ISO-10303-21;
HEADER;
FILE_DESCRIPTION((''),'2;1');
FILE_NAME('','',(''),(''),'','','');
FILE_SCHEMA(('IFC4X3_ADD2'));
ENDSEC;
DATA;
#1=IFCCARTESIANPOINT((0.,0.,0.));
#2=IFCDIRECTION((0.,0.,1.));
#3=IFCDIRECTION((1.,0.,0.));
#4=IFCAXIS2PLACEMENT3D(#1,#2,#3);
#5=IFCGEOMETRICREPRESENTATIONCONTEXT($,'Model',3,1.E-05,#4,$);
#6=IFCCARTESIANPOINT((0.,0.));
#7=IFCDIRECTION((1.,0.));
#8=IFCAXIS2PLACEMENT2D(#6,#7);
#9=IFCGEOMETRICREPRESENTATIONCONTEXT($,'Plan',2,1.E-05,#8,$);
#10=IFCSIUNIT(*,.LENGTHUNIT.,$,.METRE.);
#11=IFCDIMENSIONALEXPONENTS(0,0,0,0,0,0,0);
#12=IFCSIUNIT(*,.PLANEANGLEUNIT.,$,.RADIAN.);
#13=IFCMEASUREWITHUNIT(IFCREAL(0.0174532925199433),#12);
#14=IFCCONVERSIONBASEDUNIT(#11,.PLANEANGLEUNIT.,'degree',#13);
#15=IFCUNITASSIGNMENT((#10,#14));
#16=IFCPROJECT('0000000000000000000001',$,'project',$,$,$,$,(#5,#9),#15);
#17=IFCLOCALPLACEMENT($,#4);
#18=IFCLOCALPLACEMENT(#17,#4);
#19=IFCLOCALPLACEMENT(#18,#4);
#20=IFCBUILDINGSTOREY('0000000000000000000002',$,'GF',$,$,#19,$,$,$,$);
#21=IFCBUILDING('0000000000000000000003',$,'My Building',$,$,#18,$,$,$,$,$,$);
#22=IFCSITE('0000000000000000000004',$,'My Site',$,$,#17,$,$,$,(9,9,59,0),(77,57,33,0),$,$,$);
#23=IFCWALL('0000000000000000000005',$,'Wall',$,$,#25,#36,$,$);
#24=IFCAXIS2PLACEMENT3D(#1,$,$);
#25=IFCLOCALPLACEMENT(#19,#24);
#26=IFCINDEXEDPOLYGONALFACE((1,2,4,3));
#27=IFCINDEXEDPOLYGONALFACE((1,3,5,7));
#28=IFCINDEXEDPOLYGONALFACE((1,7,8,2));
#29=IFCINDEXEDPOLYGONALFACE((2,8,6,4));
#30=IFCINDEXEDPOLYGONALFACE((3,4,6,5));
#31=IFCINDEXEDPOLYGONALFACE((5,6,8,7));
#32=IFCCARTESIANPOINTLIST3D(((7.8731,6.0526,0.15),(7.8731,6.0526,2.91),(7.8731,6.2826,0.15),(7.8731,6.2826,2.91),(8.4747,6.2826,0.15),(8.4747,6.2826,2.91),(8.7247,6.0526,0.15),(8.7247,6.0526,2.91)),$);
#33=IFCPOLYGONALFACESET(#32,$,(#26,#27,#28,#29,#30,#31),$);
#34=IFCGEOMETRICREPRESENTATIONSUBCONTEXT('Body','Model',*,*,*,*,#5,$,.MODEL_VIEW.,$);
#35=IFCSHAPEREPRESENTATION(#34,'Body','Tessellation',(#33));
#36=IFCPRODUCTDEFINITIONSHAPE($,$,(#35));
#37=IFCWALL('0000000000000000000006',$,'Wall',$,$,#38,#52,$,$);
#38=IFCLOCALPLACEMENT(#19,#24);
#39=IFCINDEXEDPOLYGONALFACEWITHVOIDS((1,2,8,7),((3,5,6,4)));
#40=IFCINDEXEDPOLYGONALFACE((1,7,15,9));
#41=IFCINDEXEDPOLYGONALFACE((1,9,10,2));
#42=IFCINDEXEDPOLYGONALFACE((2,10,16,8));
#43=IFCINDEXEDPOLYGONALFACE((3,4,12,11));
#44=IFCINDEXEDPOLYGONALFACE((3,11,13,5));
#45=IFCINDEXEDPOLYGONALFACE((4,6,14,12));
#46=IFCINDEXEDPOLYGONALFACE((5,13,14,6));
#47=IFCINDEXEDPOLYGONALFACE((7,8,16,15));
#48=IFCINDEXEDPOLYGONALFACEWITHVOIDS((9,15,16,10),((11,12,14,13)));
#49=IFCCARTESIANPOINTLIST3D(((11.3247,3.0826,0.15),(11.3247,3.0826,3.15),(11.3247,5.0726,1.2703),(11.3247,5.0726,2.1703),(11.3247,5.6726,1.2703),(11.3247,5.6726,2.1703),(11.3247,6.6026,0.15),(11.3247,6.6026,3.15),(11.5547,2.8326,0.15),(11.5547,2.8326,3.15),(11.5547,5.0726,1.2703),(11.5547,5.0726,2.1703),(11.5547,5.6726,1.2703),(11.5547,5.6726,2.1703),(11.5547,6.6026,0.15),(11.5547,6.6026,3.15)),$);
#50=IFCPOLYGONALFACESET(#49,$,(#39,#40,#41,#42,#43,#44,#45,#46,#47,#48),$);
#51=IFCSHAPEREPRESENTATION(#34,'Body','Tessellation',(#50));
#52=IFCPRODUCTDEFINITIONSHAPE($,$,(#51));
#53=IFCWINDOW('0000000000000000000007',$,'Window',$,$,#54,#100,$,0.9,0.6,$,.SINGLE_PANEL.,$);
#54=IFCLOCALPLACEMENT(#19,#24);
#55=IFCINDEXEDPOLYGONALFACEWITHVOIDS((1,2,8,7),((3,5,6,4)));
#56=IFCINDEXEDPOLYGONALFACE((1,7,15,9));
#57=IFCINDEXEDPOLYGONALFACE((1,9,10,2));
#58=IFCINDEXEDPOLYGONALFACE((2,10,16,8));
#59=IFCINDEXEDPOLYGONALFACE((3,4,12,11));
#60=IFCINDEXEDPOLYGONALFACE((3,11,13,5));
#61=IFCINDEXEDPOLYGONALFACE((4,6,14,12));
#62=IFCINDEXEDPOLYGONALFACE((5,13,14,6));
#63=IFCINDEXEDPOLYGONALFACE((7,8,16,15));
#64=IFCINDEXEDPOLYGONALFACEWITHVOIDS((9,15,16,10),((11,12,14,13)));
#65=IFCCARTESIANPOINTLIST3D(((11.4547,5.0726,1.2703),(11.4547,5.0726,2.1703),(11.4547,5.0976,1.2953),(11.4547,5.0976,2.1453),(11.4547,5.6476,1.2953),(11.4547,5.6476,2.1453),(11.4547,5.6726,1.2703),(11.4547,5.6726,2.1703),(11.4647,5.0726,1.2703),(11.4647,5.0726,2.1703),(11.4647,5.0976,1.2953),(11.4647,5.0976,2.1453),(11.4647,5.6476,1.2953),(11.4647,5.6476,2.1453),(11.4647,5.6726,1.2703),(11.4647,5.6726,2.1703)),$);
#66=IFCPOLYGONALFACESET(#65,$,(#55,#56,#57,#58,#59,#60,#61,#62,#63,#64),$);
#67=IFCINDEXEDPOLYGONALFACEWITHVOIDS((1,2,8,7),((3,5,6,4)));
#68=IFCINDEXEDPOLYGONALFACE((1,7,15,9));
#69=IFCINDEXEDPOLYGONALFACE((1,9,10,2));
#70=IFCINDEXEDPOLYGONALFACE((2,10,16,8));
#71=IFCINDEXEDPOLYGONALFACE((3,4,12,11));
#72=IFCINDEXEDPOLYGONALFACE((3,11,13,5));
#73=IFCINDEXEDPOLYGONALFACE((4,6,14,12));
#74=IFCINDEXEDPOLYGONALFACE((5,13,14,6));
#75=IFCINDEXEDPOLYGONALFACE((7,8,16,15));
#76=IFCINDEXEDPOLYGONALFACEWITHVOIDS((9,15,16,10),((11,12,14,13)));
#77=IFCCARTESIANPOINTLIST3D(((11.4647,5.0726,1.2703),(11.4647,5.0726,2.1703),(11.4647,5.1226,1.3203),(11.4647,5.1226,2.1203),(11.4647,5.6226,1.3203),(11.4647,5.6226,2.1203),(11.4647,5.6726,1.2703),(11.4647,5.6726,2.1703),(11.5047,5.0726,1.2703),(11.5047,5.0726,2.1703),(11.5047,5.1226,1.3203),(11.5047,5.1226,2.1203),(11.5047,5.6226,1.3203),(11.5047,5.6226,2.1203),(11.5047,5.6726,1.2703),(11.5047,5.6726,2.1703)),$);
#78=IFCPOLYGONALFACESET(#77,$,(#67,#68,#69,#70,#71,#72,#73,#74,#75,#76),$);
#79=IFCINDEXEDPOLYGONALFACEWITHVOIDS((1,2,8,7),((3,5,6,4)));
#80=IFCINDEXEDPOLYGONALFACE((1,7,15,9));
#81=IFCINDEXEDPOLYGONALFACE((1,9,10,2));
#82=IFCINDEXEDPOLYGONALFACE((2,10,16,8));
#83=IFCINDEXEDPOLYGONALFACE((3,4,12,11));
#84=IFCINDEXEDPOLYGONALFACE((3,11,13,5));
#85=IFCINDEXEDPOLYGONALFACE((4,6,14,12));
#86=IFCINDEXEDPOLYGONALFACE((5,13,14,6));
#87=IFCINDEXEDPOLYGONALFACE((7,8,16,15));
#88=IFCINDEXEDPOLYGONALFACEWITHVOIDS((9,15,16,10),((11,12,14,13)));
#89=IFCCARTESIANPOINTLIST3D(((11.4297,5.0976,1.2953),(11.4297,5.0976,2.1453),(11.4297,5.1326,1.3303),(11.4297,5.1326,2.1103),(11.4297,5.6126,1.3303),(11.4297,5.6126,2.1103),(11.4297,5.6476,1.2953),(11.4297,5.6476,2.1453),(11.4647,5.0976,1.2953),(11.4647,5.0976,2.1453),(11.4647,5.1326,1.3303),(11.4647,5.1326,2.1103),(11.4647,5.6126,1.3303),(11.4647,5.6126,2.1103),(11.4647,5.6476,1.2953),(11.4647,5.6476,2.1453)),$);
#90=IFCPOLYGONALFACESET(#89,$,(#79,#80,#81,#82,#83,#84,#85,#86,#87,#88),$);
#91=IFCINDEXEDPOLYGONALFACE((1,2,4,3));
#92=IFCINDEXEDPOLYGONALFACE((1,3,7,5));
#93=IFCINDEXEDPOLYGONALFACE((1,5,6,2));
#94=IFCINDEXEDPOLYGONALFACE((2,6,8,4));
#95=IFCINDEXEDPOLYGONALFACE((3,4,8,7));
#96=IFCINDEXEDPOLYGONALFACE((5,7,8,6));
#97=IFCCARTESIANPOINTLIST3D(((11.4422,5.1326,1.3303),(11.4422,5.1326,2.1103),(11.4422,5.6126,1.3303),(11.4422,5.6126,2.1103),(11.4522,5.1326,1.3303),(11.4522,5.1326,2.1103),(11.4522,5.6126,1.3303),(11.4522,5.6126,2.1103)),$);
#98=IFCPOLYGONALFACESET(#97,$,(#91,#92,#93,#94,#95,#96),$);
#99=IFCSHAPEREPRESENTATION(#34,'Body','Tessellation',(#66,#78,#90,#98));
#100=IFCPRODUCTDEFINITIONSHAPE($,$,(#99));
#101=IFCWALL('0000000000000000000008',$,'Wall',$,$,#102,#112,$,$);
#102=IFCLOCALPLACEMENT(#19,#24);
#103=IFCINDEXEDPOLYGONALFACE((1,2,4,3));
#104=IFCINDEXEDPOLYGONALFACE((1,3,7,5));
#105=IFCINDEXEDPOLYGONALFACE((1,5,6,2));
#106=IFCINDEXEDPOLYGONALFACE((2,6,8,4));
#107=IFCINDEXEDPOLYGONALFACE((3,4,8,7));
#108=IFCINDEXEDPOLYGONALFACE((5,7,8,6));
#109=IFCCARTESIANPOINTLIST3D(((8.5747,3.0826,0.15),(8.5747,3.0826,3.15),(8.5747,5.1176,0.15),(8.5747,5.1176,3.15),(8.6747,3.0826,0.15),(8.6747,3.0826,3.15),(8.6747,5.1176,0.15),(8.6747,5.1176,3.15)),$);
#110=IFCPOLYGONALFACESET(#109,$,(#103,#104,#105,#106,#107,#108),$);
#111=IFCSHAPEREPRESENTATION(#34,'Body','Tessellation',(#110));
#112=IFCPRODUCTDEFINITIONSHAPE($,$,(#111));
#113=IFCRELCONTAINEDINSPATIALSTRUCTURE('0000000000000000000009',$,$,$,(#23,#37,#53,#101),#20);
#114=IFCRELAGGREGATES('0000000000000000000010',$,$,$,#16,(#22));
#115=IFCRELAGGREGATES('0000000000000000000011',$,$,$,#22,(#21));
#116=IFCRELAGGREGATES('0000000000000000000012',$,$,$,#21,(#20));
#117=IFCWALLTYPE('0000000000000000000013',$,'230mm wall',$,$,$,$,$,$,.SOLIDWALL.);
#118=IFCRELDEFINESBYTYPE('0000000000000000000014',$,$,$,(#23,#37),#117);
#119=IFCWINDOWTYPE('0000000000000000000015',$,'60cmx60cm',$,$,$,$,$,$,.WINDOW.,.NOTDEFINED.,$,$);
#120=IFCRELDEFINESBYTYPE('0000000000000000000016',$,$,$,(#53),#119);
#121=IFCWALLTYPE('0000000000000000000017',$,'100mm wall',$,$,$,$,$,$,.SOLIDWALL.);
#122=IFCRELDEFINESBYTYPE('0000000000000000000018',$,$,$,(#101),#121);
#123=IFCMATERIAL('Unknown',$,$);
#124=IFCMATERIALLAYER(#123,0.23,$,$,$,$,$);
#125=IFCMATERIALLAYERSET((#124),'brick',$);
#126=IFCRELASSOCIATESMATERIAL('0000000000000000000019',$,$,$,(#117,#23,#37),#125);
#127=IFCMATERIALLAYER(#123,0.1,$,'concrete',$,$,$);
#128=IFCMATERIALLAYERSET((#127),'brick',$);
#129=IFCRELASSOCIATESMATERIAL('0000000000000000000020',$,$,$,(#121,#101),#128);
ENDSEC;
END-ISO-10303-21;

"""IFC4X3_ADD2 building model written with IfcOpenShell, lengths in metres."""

from ifc_helpers import new_model, entity, si_unit, converted_unit, frame, origin_with_axes, origin_2d_with_axis, place, context, subcontext, project, spatial, line, indexed_curve, outline, extrude, shape, source, transform, mapped, material, layer, layer_set, layer_usage, type_object, type_shapes, element, fill, save


model = new_model("IFC4X3_ADD2")

# Units and contexts
model_context = context("Model", 3, precision=1e-05, world=origin_with_axes())
plan_context = context("Plan", 2, precision=1e-05, world=origin_2d_with_axis())
body_context_1 = subcontext(model_context, "Body", "Model", "MODEL_VIEW")
body_context_2 = subcontext(plan_context, "Body", "Plan", "PLAN_VIEW")
ifc_project = project(units=[si_unit("LENGTHUNIT", "METRE"), converted_unit("PLANEANGLEUNIT", "degree", entity("IfcReal", 0.0174532925199433), si_unit("PLANEANGLEUNIT", "RADIAN"), dimensions=[0, 0, 0, 0, 0, 0, 0])], contexts=[model_context, plan_context])

# Site, building, storey
site_placement = place(None, origin_with_axes())
site = spatial("IfcSite", under=ifc_project, at=site_placement, Name="My Site", RefLatitude=(9, 9, 59, 0), RefLongitude=(77, 57, 33, 0))
building_placement = place(site_placement, origin_with_axes())
building = spatial("IfcBuilding", under=site, at=building_placement, Name="My Building")
storey_placement = place(building_placement, origin_with_axes())
storey = spatial("IfcBuildingStorey", under=building, at=storey_placement, Name="GF")

# Shared definitions
ifc_material_1 = material(Name="Unknown")

# Shared definitions
shared_shape_1 = source(origin_with_axes(), body_context_1, "Body", "SweptSolid", [
    extrude(outline(indexed_curve([(0.0, 0.0), (0.6, 0.0), (0.6, 0.9), (0.0, 0.9)], segments=[line(1, 2, 3, 4, 1)])), frame((0.0, -0.6, 0.0), z_axis=(0.0, -1.0, 0.0), x_axis=(1.0, 0.0, 0.0)), (0.0, 0.0, -1.0), 1.2),
])
window_type = type_object("IfcWindowType", Name="60cmx60cm", PartitioningType="NOTDEFINED", PredefinedType="WINDOW")
shared_shape_2 = source(origin_with_axes(), body_context_1, "Body", "SweptSolid", [
    extrude(outline(indexed_curve([(0.0, 0.0), (0.6, 0.0), (0.6, 0.9), (0.0, 0.9)], segments=[line(1, 2, 3, 4, 1)]), holes=[indexed_curve([(0.025, 0.025), (0.575, 0.025), (0.575, 0.875), (0.025, 0.875)], segments=[line(1, 2, 3, 4, 1)])]), frame((0.0, 0.09, 0.0), z_axis=(0.0, -1.0, 0.0), x_axis=(1.0, 0.0, 0.0)), (0.0, 0.0, -1.0), 0.01),
    extrude(outline(indexed_curve([(0.0, 0.0), (0.6, 0.0), (0.6, 0.9), (0.0, 0.9)], segments=[line(1, 2, 3, 4, 1)]), holes=[indexed_curve([(0.05, 0.05), (0.55, 0.05), (0.55, 0.85), (0.05, 0.85)], segments=[line(1, 2, 3, 4, 1)])]), frame((0.0, 0.05, 0.0), z_axis=(0.0, -1.0, 0.0), x_axis=(1.0, 0.0, 0.0)), (0.0, 0.0, -1.0), 0.04),
    extrude(outline(indexed_curve([(0.0, 0.0), (0.55, 0.0), (0.55, 0.85), (0.0, 0.85)], segments=[line(1, 2, 3, 4, 1)]), holes=[indexed_curve([(0.035, 0.035), (0.515, 0.035), (0.515, 0.815), (0.035, 0.815)], segments=[line(1, 2, 3, 4, 1)])]), frame((0.025, 0.09, 0.025), z_axis=(0.0, -1.0, 0.0), x_axis=(1.0, 0.0, 0.0)), (0.0, 0.0, -1.0), 0.035),
    extrude(outline(indexed_curve([(0.035, 0.035), (0.515, 0.035), (0.515, 0.815), (0.035, 0.815)], segments=[line(1, 2, 3, 4, 1)])), frame((0.025, 0.1025, 0.025), z_axis=(0.0, -1.0, 0.0), x_axis=(1.0, 0.0, 0.0)), (0.0, 0.0, -1.0), 0.01),
])
shared_shape_3 = source(origin_with_axes(), body_context_2, "Body", "Curve2D", [
    entity("IfcIndexedPolyCurve", entity("IfcCartesianPointList2D", [[0.05, 0.05], [0.55, 0.05]])),
    entity("IfcIndexedPolyCurve", entity("IfcCartesianPointList2D", [[0.0, 0.1], [0.025, 0.1], [0.025, 0.09], [0.05, 0.09], [0.05, 0.05], [0.0, 0.05]]), [entity("IfcLineIndex", [1, 2, 3, 4, 5, 6, 1])]),
    entity("IfcIndexedPolyCurve", entity("IfcCartesianPointList2D", [[0.6, 0.1], [0.575, 0.1], [0.575, 0.09], [0.55, 0.09], [0.55, 0.05], [0.6, 0.05]]), [entity("IfcLineIndex", [1, 2, 3, 4, 5, 6, 1])]),
    entity("IfcIndexedPolyCurve", entity("IfcCartesianPointList2D", [[0.025, 0.09], [0.06, 0.09], [0.06, 0.125], [0.025, 0.125]]), [entity("IfcLineIndex", [1, 2, 3, 4, 1])]),
    entity("IfcIndexedPolyCurve", entity("IfcCartesianPointList2D", [[0.575, 0.09], [0.54, 0.09], [0.54, 0.125], [0.575, 0.125]]), [entity("IfcLineIndex", [1, 2, 3, 4, 1])]),
    entity("IfcIndexedPolyCurve", entity("IfcCartesianPointList2D", [[0.06, 0.09], [0.54, 0.09]])),
    entity("IfcIndexedPolyCurve", entity("IfcCartesianPointList2D", [[0.06, 0.125], [0.54, 0.125]])),
    entity("IfcIndexedPolyCurve", entity("IfcCartesianPointList2D", [[0.06, 0.1075], [0.54, 0.1075]])),
])
type_shapes(window_type, [shared_shape_2, shared_shape_3])

# Shared definitions
ifc_layer_1 = layer(ifc_material_1, 0.23)
ifc_layer_set_1 = layer_set([ifc_layer_1], Name="brick")
wall_type_1 = type_object("IfcWallType", Name="230mm wall", PredefinedType="SOLIDWALL", material=ifc_layer_set_1)
wall_1_placement = place(storey_placement, frame((11.5547, 2.8326, 0.15), z_axis=(0.0, 0.0, 1.0), x_axis=(0.0, 1.0, 0.0)))
placement = place(wall_1_placement, frame((2.24, 0.0, 1.1203), z_axis=(0.0, 0.0, 1.0), x_axis=(1.0, 0.0, 0.0)))

# Wall
ifc_layer_usage_1 = layer_usage(ifc_layer_set_1, "AXIS2", "POSITIVE", 0.0)
wall_2_placement = place(storey_placement, frame((7.8731, 6.0526, 0.15), z_axis=(0.0, 0.0, 1.0), x_axis=(1.0, 0.0, 0.0)))
element("IfcWall", 1, at=wall_2_placement, inside=storey, type_object=wall_type_1, material=ifc_layer_usage_1, Name="Wall", context=body_context_1, shape_type="SweptSolid", body=[
    extrude(outline(indexed_curve([(0.0, 0.0), (0.0, 0.23), (0.6015, 0.23), (0.8515, 0.0)], segments=[line(1, 2, 3, 4, 1)])), origin_with_axes(), (0.0, 0.0, 1.0), 2.76),
])

# Wall, opening, window
ifc_layer_usage_2 = layer_usage(ifc_layer_set_1, "AXIS2", "POSITIVE", 0.0)
wall_3_placement = place(storey_placement, frame((11.5547, 2.8326, 0.15), z_axis=(0.0, 0.0, 1.0), x_axis=(0.0, 1.0, 0.0)))
wall_3 = element("IfcWall", 2, at=wall_3_placement, inside=storey, type_object=wall_type_1, material=ifc_layer_usage_2, Name="Wall", context=body_context_1, shape_type="SweptSolid", body=[
    extrude(outline(indexed_curve([(0.0, 0.0), (0.25, 0.23), (3.77, 0.23), (3.77, 0.0)], segments=[line(1, 2, 3, 4, 1)])), origin_with_axes(), (0.0, 0.0, 1.0), 3.0),
])
opening_1_placement = place(wall_3_placement, frame((2.24, 0.0, 1.1203), z_axis=(0.0, 0.0, 1.0), x_axis=(1.0, 0.0, 0.0)))
opening_1 = element("IfcOpeningElement", 3, at=opening_1_placement, cuts=wall_3, PredefinedType="OPENING", context=body_context_1, shape_type="MappedRepresentation", body=[
    mapped(shared_shape_1, transform((0.0, 0.0, 0.0), x_axis=(1.0, 0.0, 0.0), y_axis=(0.0, 1.0, 0.0), z_axis=(0.0, 0.0, 1.0), scale=1.0)),
])
window_1_placement = place(placement, frame((0.0, 0.0, 0.0), z_axis=(0.0, 0.0, 1.0), x_axis=(1.0, 0.0, 0.0)))
window_1 = element("IfcWindow", 4, at=window_1_placement, inside=storey, type_object=window_type, Name="Window", OverallHeight=0.9, OverallWidth=0.6, PartitioningType="SINGLE_PANEL", shapes=[
    shape(body_context_1, "Body", "MappedRepresentation", [mapped(shared_shape_2, transform((0.0, 0.0, 0.0), x_axis=(1.0, 0.0, 0.0), y_axis=(0.0, 1.0, 0.0), z_axis=(0.0, 0.0, 1.0), scale=1.0))]),
    shape(body_context_2, "Body", "MappedRepresentation", [mapped(shared_shape_3, transform((0.0, 0.0, 0.0), x_axis=(1.0, 0.0, 0.0), y_axis=(0.0, 1.0, 0.0), z_axis=(0.0, 0.0, 1.0), scale=1.0))]),
])
fill(opening_1, window_1)

# Wall
ifc_layer_2 = layer(ifc_material_1, 0.1, Name="concrete")
ifc_layer_set_2 = layer_set([ifc_layer_2], Name="brick")
ifc_layer_usage_3 = layer_usage(ifc_layer_set_2, "AXIS2", "POSITIVE", 0.0)
wall_type_2 = type_object("IfcWallType", Name="100mm wall", PredefinedType="SOLIDWALL", material=ifc_layer_set_2)
wall_4_placement = place(storey_placement, frame((8.6747, 3.0826, 0.15), z_axis=(0.0, 0.0, 1.0), x_axis=(0.0, 1.0, 0.0)))
element("IfcWall", 5, at=wall_4_placement, inside=storey, type_object=wall_type_2, material=ifc_layer_usage_3, Name="Wall", context=body_context_1, shape_type="SweptSolid", body=[
    extrude(outline(indexed_curve([(0.0, 0.0), (0.0, 0.1), (2.035, 0.1), (2.035, 0.0)], segments=[line(1, 2, 3, 4, 1)])), origin_with_axes(), (0.0, 0.0, 1.0), 3.0),
])

save(model, "model.ifc")
